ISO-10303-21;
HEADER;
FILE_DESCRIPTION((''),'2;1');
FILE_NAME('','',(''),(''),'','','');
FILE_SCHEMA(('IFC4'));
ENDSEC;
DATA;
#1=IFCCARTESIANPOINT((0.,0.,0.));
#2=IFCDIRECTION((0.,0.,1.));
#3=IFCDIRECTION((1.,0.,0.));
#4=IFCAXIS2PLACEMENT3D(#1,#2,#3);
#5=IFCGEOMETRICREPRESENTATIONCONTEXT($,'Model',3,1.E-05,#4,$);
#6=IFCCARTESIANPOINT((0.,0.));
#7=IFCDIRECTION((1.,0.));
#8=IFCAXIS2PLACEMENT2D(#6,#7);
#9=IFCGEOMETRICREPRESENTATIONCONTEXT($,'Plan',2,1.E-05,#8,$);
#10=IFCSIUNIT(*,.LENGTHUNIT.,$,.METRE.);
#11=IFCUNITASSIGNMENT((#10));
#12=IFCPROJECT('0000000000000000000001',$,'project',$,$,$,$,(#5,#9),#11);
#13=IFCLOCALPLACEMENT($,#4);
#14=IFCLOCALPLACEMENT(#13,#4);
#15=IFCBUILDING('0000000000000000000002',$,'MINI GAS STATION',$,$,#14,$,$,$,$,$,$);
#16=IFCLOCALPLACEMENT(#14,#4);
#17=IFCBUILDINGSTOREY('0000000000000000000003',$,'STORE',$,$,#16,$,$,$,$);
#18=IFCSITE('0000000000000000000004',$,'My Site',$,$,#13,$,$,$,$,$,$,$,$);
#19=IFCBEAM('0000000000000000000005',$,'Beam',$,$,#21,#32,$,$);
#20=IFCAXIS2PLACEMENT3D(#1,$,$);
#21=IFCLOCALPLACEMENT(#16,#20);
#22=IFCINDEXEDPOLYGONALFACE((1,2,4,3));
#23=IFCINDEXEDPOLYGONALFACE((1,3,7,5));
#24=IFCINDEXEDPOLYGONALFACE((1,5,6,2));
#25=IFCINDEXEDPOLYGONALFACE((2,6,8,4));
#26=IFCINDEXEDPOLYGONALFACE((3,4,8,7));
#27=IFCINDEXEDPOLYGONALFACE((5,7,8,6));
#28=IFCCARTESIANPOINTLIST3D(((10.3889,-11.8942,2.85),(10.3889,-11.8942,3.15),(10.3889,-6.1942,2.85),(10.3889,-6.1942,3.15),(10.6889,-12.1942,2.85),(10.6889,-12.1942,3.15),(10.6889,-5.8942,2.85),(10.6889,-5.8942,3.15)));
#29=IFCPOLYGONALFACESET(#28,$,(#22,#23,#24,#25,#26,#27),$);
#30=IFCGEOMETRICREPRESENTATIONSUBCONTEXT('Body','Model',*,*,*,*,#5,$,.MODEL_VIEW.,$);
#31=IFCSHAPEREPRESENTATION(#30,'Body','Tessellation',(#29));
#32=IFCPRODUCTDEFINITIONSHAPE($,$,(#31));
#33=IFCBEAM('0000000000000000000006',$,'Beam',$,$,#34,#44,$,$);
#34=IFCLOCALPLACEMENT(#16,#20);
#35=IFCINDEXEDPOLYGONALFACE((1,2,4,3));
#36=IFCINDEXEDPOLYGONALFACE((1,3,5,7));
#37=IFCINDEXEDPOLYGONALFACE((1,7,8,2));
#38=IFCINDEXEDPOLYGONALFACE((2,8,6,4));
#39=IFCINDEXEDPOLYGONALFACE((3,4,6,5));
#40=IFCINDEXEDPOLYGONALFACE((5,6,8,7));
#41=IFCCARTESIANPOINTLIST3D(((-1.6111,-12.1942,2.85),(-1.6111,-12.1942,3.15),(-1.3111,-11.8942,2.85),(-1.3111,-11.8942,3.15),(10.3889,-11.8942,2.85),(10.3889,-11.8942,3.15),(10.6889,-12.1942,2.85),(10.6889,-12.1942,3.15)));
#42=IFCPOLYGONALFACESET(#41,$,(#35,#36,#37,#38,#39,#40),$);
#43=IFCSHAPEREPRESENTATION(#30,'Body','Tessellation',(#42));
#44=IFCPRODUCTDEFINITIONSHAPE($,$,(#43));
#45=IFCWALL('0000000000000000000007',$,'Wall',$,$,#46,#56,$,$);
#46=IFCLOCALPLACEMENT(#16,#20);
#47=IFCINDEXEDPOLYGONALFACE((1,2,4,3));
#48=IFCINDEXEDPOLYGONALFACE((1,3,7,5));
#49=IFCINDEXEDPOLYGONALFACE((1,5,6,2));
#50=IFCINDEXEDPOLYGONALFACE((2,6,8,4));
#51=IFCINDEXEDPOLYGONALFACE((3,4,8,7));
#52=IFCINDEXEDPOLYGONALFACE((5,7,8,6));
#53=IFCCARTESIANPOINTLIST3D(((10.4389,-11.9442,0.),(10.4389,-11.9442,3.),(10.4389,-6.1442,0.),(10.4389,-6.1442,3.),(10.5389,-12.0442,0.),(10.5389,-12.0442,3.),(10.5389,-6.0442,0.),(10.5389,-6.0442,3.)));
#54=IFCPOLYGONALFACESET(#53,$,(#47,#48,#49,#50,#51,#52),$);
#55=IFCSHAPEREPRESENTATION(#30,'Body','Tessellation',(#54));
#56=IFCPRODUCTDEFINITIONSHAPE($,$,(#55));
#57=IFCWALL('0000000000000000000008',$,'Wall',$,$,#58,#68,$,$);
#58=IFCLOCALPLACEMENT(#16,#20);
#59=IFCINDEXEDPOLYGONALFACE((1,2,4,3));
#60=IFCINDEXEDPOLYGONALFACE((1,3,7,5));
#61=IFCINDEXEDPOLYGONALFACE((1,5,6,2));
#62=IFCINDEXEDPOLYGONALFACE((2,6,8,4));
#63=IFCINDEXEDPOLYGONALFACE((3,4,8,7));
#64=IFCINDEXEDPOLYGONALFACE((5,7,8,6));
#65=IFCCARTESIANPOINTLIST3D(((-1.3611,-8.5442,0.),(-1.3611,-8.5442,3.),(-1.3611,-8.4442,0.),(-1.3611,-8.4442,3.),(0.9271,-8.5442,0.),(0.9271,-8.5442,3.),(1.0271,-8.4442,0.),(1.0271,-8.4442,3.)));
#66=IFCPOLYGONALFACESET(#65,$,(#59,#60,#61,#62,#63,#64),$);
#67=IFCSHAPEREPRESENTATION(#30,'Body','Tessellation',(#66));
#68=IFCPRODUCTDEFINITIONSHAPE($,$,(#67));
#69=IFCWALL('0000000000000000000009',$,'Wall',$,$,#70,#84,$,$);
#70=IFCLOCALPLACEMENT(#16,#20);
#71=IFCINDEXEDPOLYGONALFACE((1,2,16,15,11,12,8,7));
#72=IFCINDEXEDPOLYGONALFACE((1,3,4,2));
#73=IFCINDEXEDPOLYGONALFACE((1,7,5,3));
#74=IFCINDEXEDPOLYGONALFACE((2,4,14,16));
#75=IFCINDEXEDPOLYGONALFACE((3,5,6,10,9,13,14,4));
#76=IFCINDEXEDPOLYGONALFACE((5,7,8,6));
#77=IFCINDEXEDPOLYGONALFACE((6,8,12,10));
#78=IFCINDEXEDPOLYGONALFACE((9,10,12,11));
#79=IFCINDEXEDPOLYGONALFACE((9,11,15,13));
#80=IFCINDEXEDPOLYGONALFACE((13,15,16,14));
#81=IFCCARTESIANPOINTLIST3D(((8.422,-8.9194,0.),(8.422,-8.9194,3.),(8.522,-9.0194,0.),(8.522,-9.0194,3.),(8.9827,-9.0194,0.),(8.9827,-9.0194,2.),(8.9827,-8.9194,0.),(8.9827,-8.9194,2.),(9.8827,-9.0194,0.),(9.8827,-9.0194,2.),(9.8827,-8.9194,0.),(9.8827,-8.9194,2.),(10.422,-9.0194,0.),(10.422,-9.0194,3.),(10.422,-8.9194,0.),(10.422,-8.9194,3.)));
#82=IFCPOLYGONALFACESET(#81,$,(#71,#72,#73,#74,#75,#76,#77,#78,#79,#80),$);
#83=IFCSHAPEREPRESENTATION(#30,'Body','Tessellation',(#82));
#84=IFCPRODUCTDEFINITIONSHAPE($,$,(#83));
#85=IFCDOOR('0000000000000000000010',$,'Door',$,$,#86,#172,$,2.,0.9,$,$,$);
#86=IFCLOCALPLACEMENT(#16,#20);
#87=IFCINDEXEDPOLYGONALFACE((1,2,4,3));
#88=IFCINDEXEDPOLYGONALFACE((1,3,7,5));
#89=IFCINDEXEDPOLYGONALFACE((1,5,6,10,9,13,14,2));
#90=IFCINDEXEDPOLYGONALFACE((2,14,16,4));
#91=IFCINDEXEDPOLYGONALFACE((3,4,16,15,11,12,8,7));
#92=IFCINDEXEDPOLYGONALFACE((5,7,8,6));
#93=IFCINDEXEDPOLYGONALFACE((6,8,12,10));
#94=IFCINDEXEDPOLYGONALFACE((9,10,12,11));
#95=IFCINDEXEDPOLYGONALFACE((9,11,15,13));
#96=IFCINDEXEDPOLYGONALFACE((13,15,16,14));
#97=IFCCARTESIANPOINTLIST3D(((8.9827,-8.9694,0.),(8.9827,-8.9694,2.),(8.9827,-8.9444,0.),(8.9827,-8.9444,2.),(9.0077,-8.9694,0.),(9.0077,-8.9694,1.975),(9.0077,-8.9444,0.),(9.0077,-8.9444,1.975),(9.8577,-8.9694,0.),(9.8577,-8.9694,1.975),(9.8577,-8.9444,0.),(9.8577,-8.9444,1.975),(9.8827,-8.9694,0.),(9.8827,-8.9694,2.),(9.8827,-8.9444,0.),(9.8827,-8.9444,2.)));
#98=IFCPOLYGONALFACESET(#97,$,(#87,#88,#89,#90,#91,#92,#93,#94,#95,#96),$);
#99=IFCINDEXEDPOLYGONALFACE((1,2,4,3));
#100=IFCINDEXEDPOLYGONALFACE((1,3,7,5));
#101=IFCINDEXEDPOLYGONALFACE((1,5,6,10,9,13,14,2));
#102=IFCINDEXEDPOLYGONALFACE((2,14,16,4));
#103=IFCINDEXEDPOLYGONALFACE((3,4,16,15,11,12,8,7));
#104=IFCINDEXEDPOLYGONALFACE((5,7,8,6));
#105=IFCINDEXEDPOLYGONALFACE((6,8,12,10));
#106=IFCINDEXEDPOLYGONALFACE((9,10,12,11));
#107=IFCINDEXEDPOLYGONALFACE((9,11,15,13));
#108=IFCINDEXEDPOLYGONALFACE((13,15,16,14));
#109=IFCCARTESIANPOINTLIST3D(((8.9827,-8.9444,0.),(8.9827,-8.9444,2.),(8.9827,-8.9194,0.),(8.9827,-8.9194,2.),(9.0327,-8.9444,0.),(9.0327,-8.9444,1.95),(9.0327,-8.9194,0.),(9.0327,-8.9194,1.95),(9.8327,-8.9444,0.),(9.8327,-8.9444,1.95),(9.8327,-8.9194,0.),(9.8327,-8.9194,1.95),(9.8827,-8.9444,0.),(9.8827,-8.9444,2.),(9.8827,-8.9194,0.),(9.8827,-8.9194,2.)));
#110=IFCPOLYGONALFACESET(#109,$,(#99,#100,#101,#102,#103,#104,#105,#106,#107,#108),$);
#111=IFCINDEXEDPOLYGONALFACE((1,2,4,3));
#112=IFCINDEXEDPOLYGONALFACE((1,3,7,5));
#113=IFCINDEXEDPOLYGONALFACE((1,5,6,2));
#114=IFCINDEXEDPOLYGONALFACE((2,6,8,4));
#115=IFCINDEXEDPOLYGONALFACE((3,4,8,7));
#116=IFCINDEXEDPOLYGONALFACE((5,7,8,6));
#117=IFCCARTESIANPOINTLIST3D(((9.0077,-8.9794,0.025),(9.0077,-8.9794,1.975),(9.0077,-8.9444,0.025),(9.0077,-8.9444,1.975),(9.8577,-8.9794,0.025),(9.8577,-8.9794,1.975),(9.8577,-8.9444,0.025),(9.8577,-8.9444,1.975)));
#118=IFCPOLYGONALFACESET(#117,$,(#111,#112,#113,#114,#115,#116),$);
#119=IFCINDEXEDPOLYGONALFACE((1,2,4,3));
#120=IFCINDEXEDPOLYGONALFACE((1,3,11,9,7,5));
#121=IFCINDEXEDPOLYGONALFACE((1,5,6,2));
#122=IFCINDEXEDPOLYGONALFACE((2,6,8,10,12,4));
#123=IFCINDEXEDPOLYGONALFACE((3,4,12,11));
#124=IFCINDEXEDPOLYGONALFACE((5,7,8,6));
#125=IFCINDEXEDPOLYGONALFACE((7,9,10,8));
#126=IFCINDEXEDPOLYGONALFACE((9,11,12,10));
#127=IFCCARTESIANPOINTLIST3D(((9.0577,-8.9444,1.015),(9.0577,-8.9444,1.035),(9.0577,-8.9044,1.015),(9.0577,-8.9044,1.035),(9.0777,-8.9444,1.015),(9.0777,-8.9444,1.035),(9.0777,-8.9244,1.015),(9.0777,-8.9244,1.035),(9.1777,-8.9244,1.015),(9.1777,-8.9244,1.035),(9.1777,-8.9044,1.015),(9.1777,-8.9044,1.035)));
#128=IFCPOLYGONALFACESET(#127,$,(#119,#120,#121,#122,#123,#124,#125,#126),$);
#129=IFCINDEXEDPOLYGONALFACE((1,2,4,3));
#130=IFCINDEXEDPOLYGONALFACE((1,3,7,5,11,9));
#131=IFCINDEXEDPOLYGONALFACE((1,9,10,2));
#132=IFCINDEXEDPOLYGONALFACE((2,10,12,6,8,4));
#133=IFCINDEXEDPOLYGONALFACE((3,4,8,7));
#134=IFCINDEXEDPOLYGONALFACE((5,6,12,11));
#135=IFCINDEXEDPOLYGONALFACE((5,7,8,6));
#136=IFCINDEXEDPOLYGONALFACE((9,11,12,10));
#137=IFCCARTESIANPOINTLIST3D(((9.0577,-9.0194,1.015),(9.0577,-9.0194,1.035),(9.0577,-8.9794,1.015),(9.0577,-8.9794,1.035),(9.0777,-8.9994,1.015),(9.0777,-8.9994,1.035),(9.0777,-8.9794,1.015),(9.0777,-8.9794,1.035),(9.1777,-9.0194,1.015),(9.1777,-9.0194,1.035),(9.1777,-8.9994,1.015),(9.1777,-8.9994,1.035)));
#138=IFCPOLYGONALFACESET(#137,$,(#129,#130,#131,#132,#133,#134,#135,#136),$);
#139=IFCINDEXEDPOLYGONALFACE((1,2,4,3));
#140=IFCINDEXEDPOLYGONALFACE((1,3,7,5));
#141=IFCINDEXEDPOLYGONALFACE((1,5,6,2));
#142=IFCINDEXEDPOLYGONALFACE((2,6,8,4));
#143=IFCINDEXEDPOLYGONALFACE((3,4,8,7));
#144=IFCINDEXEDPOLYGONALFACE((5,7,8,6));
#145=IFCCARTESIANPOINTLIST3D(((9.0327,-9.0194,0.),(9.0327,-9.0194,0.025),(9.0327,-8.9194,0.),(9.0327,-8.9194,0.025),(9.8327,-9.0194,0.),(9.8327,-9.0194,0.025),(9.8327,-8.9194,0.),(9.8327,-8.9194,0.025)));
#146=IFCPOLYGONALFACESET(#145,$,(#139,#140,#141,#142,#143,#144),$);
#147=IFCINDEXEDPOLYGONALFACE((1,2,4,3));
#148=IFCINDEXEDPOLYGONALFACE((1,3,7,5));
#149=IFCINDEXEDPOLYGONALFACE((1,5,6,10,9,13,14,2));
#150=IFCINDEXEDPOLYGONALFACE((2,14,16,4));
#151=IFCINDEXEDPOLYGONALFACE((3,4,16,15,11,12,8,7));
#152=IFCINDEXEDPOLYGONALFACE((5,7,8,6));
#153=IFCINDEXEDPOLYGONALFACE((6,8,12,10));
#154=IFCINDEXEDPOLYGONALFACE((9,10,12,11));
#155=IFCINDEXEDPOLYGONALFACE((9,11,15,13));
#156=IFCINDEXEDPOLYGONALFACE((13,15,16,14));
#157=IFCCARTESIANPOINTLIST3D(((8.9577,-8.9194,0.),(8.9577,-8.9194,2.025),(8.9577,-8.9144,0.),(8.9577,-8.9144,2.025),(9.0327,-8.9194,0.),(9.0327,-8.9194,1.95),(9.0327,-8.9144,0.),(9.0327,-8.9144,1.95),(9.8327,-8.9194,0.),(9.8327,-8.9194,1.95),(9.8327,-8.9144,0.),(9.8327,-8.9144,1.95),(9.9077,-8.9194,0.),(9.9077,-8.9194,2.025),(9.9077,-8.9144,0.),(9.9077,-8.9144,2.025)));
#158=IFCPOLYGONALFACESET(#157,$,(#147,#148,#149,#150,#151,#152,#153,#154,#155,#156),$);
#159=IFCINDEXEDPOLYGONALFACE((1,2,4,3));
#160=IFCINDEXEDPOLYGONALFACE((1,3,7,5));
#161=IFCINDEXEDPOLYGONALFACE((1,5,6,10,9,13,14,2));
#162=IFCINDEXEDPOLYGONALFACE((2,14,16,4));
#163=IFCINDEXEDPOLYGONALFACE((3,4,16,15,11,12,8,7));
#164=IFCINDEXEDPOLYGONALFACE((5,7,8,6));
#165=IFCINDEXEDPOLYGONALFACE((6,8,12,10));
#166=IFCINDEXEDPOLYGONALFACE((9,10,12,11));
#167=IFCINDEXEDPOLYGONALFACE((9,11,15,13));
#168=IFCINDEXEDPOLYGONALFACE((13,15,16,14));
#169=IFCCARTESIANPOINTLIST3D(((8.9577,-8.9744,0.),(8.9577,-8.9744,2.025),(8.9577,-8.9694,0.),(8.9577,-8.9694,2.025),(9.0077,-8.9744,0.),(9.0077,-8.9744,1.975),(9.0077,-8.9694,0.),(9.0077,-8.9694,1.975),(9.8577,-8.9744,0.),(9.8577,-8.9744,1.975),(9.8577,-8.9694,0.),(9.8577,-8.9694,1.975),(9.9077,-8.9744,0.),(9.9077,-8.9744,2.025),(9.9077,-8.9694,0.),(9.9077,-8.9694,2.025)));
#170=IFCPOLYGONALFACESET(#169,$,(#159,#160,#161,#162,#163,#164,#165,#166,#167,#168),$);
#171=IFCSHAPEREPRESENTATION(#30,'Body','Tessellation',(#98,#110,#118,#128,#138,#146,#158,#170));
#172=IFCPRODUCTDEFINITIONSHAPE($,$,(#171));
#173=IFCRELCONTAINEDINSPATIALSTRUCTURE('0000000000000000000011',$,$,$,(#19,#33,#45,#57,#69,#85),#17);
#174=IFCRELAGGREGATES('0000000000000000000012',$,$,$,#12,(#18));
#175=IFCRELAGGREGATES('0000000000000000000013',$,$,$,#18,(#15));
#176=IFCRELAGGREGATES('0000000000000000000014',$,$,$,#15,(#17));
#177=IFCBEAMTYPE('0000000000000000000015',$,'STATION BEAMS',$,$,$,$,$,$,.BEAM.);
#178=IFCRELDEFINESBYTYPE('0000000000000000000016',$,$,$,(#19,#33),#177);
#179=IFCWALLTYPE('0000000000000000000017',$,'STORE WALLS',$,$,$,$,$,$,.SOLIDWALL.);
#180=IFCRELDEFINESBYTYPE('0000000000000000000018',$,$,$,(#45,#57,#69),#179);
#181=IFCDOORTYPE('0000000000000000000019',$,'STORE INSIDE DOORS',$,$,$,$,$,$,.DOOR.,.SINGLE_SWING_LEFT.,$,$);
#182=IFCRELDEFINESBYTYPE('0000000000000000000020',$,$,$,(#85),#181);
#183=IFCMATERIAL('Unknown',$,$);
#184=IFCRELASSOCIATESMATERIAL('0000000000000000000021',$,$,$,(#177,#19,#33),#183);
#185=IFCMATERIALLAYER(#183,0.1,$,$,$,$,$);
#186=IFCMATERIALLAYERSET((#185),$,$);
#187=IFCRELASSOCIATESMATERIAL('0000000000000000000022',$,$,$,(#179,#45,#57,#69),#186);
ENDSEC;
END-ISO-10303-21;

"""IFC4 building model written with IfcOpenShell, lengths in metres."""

from ifc_helpers import new_model, entity, si_unit, frame, origin_with_axes, origin_2d_with_axis, place, context, subcontext, project, spatial, line, indexed_curve, rectangle, outline, extrude, clip, halfspace, shape, source, transform, mapped, material, layer, layer_set, layer_usage, material_profile, profile_set, profile_usage, type_object, type_shapes, element, fill, save


model = new_model("IFC4")

# Units and contexts
model_context = context("Model", 3, precision=1e-05, world=origin_with_axes())
plan_context = context("Plan", 2, precision=1e-05, world=origin_2d_with_axis())
body_context_1 = subcontext(model_context, "Body", "Model", "MODEL_VIEW")
body_context_2 = subcontext(plan_context, "Body", "Plan", "PLAN_VIEW")
ifc_project = project(units=[si_unit("LENGTHUNIT", "METRE")], contexts=[model_context, plan_context])

# Site, building, storey
site_placement = place(None, origin_with_axes())
site = spatial("IfcSite", under=ifc_project, at=site_placement, Name="My Site")
building_placement = place(site_placement, origin_with_axes())
building = spatial("IfcBuilding", under=site, at=building_placement, Name="MINI GAS STATION")
storey_placement = place(building_placement, origin_with_axes())
storey = spatial("IfcBuildingStorey", under=building, at=storey_placement, Name="STORE")

# Beams
ifc_material = material(Name="Unknown")
ifc_material_profile = material_profile(ifc_material, rectangle(XDim=0.3, YDim=0.3))
ifc_profile_set = profile_set([ifc_material_profile])
ifc_profile_usage_1 = profile_usage(ifc_profile_set, cardinal=5)
beam_type = type_object("IfcBeamType", Name="STATION BEAMS", PredefinedType="BEAM", material=ifc_profile_set)
beam_1_placement = place(storey_placement, frame((10.5389, -5.8942, 3.0), z_axis=(0.0, -1.0, 0.0), x_axis=(1.0, 0.0, 0.0)))
element("IfcBeam", 1, at=beam_1_placement, inside=storey, type_object=beam_type, material=ifc_profile_usage_1, Name="Beam", context=body_context_1, shape_type="Clipping", body=[
    clip(clip(extrude(rectangle(XDim=0.3, YDim=0.3), origin_with_axes(), (0.0, 0.0, 1.0), 6.3), halfspace(frame((0.15, -3.0, 6.3), z_axis=(-0.707105, 0.0, 0.707108), x_axis=(0.0, 1.0, 0.0)), False)), halfspace(frame((0.15, -3.0, 0.0), z_axis=(-0.707108, 0.0, -0.707105), x_axis=(0.0, 1.0, 0.0)), False)),
])
ifc_profile_usage_2 = profile_usage(ifc_profile_set, cardinal=5)
beam_2_placement = place(storey_placement, frame((10.6889, -12.0442, 3.0), z_axis=(-1.0, -0.000001, 0.000001), x_axis=(0.000001, -1.0, 0.0)))
element("IfcBeam", 2, at=beam_2_placement, inside=storey, type_object=beam_type, material=ifc_profile_usage_2, Name="Beam", context=body_context_1, shape_type="Clipping", body=[
    clip(clip(extrude(rectangle(XDim=0.3, YDim=0.3), origin_with_axes(), (0.0, 0.0, 1.0), 12.3), halfspace(frame((0.15, -3.0, 12.3), z_axis=(-0.707111, 0.0, 0.707103), x_axis=(-0.000001, 1.0, 0.0)), False)), halfspace(frame((0.15, -3.0, 0.0), z_axis=(-0.707108, 0.0, -0.707106), x_axis=(0.000001, 1.0, 0.0)), False)),
])

# Wall
ifc_layer_1 = layer(ifc_material, 0.1)
ifc_layer_set_1 = layer_set([ifc_layer_1])
ifc_layer_usage_1 = layer_usage(ifc_layer_set_1, "AXIS2", "POSITIVE", 0.0)
wall_type_1 = type_object("IfcWallType", Name="STORE WALLS", PredefinedType="SOLIDWALL", material=ifc_layer_set_1)
wall_1_placement = place(storey_placement, frame((10.5389, -12.0442, 0.0), z_axis=(0.0, 0.0, 1.0), x_axis=(0.0, 1.0, 0.0)))
element("IfcWall", 3, at=wall_1_placement, inside=storey, type_object=wall_type_1, material=ifc_layer_usage_1, Name="Wall", context=body_context_1, shape_type="SweptSolid", body=[
    extrude(outline(indexed_curve([(0.0, 0.0), (0.1, 0.1), (5.9, 0.1), (6.0, 0.0)], segments=[line(1, 2, 3, 4, 1)])), origin_with_axes(), (0.0, 0.0, 1.0), 3.0),
])

# Wall
ifc_layer_usage_2 = layer_usage(ifc_layer_set_1, "AXIS2", "POSITIVE", 0.0)
wall_2_placement = place(storey_placement, frame((1.0271, -8.4442, 0.0), z_axis=(0.0, 0.0, 1.0), x_axis=(-1.0, 0.0, 0.0)))
element("IfcWall", 4, at=wall_2_placement, inside=storey, type_object=wall_type_1, material=ifc_layer_usage_2, Name="Wall", context=body_context_1, shape_type="SweptSolid", body=[
    extrude(outline(indexed_curve([(0.0, 0.0), (0.1, 0.1), (2.3881, 0.1), (2.3881, 0.0)], segments=[line(1, 2, 3, 4, 1)])), origin_with_axes(), (0.0, 0.0, 1.0), 3.0),
])

# Wall, opening, door
ifc_layer_usage_3 = layer_usage(ifc_layer_set_1, "AXIS2", "POSITIVE", 0.0)
wall_3_placement = place(storey_placement, frame((10.422, -8.9194, 0.0), z_axis=(0.0, 0.0, 1.0), x_axis=(-1.0, 0.0, 0.0)))
wall_3 = element("IfcWall", 5, at=wall_3_placement, inside=storey, type_object=wall_type_1, material=ifc_layer_usage_3, Name="Wall", context=body_context_1, shape_type="SweptSolid", body=[
    extrude(outline(indexed_curve([(0.0, 0.0), (0.0, 0.1), (1.9, 0.1), (2.0, 0.0)], segments=[line(1, 2, 3, 4, 1)])), origin_with_axes(), (0.0, 0.0, 1.0), 3.0),
])
shared_shape_1 = source(origin_with_axes(), body_context_1, "Body", "SweptSolid", [
    extrude(outline(indexed_curve([(0.0, 0.0), (0.9, 0.0), (0.9, 2.0), (0.0, 2.0)], segments=[line(1, 2, 3, 4, 1)])), frame((0.0, -0.6, 0.0), z_axis=(0.0, -1.0, 0.0), x_axis=(1.0, 0.0, 0.0)), (0.0, 0.0, -1.0), 1.2),
])
opening_1_placement = place(wall_3_placement, frame((0.5393, 0.0, 0.0), z_axis=(0.0, 0.0, 1.0), x_axis=(1.0, 0.0, 0.0)))
opening_1 = element("IfcOpeningElement", 6, at=opening_1_placement, cuts=wall_3, PredefinedType="OPENING", context=body_context_1, shape_type="MappedRepresentation", body=[
    mapped(shared_shape_1, transform((0.0, 0.0, 0.0), x_axis=(1.0, 0.0, 0.0), y_axis=(0.0, 1.0, 0.0), z_axis=(0.0, 0.0, 1.0), scale=1.0)),
])
door_type_1 = type_object("IfcDoorType", Name="STORE INSIDE DOORS", OperationType="SINGLE_SWING_LEFT", PredefinedType="DOOR")
shared_shape_2 = source(origin_with_axes(), body_context_1, "Body", "SweptSolid", [
    extrude(outline(indexed_curve([(0.0, 0.0), (0.0, 2.0), (0.9, 2.0), (0.9, 0.0), (0.875, 0.0), (0.875, 1.975), (0.025, 1.975), (0.025, 0.0)], segments=[line(1, 2, 3, 4, 5, 6, 7, 8, 1)])), frame((0.0, 0.025, 0.0), z_axis=(0.0, -1.0, 0.0), x_axis=(1.0, 0.0, 0.0)), (0.0, 0.0, -1.0), 0.025),
    extrude(outline(indexed_curve([(0.0, 0.0), (0.0, 2.0), (0.9, 2.0), (0.9, 0.0), (0.85, 0.0), (0.85, 1.95), (0.05, 1.95), (0.05, 0.0)], segments=[line(1, 2, 3, 4, 5, 6, 7, 8, 1)])), frame((0.0, 0.0, 0.0), z_axis=(0.0, -1.0, 0.0), x_axis=(1.0, 0.0, 0.0)), (0.0, 0.0, -1.0), 0.025),
    extrude(outline(indexed_curve([(0.0, 0.0), (0.85, 0.0), (0.85, 0.035), (0.0, 0.035)], segments=[line(1, 2, 3, 4, 1)])), frame((0.025, 0.025, 0.025), z_axis=(0.0, 0.0, 1.0), x_axis=(1.0, 0.0, 0.0)), (0.0, 0.0, 1.0), 1.95),
    extrude(outline(indexed_curve([(0.0, 0.0), (0.0, -0.04), (-0.12, -0.04), (-0.12, -0.02), (-0.02, -0.02), (-0.02, 0.0)], segments=[line(1, 2, 3, 4, 5, 6, 1)])), frame((0.825, 0.025, 1.015), z_axis=(0.0, 0.0, 1.0), x_axis=(1.0, 0.0, 0.0)), (0.0, 0.0, 1.0), 0.02),
    extrude(outline(indexed_curve([(0.0, 0.0), (0.0, 0.04), (-0.12, 0.04), (-0.12, 0.02), (-0.02, 0.02), (-0.02, 0.0)], segments=[line(1, 2, 3, 4, 5, 6, 1)])), frame((0.825, 0.06, 1.015), z_axis=(0.0, 0.0, 1.0), x_axis=(1.0, 0.0, 0.0)), (0.0, 0.0, 1.0), 0.02),
    extrude(outline(indexed_curve([(0.0, 0.0), (0.8, 0.0), (0.8, 0.1), (0.0, 0.1)], segments=[line(1, 2, 3, 4, 1)])), frame((0.05, 0.0, 0.0), z_axis=(0.0, 0.0, 1.0), x_axis=(1.0, 0.0, 0.0)), (0.0, 0.0, 1.0), 0.025),
    extrude(outline(indexed_curve([(0.0, 0.0), (0.0, 2.025), (0.95, 2.025), (0.95, 0.0), (0.875, 0.0), (0.875, 1.95), (0.075, 1.95), (0.075, 0.0)], segments=[line(1, 2, 3, 4, 5, 6, 7, 8, 1)])), frame((-0.025, -0.005, 0.0), z_axis=(0.0, -1.0, 0.0), x_axis=(1.0, 0.0, 0.0)), (0.0, 0.0, -1.0), 0.005),
    extrude(outline(indexed_curve([(0.0, 0.0), (0.0, 2.025), (0.95, 2.025), (0.95, 0.0), (0.9, 0.0), (0.9, 1.975), (0.05, 1.975), (0.05, 0.0)], segments=[line(1, 2, 3, 4, 5, 6, 7, 8, 1)])), frame((-0.025, 0.05, 0.0), z_axis=(0.0, -1.0, 0.0), x_axis=(1.0, 0.0, 0.0)), (0.0, 0.0, -1.0), 0.005),
])
shared_shape_3 = source(origin_with_axes(), body_context_2, "Body", "Curve2D", [
    entity("IfcIndexedPolyCurve", entity("IfcCartesianPointList2D", [[0.0, 0.0], [0.0, 0.05], [0.025, 0.05], [0.025, 0.025], [0.05, 0.025], [0.05, 0.0]]), [entity("IfcLineIndex", [1, 2, 3, 4, 5, 6, 1])]),
    entity("IfcIndexedPolyCurve", entity("IfcCartesianPointList2D", [[0.9, 0.0], [0.9, 0.05], [0.875, 0.05], [0.875, 0.025], [0.85, 0.025], [0.85, 0.0]]), [entity("IfcLineIndex", [1, 2, 3, 4, 5, 6, 1])]),
    entity("IfcTrimmedCurve", entity("IfcEllipse", entity("IfcAxis2Placement2D", entity("IfcCartesianPoint", [0.06, 0.05]), entity("IfcDirection", [1.0, 0.0])), 0.815, 0.85), [entity("IfcCartesianPoint", [0.875, 0.05])], [entity("IfcCartesianPoint", [0.06, 0.9])], True, "CARTESIAN"),
    entity("IfcIndexedPolyCurve", entity("IfcCartesianPointList2D", [[0.025, 0.05], [0.06, 0.05], [0.06, 0.9], [0.025, 0.9]]), [entity("IfcLineIndex", [1, 2, 3, 4, 1])]),
])
type_shapes(door_type_1, [shared_shape_2, shared_shape_3])
door_1_placement = place(opening_1_placement, frame((0.0, 0.0, 0.0), z_axis=(0.0, 0.0, 1.0), x_axis=(1.0, 0.0, 0.0)))
door_1 = element("IfcDoor", 7, at=door_1_placement, inside=storey, type_object=door_type_1, Name="Door", OverallHeight=2.0, OverallWidth=0.9, shapes=[
    shape(body_context_1, "Body", "MappedRepresentation", [mapped(shared_shape_2, transform((0.0, 0.0, 0.0), x_axis=(1.0, 0.0, 0.0), y_axis=(0.0, 1.0, 0.0), z_axis=(0.0, 0.0, 1.0), scale=1.0))]),
    shape(body_context_2, "Body", "MappedRepresentation", [mapped(shared_shape_3, transform((0.0, 0.0, 0.0), x_axis=(1.0, 0.0, 0.0), y_axis=(0.0, 1.0, 0.0), z_axis=(0.0, 0.0, 1.0), scale=1.0))]),
])
fill(opening_1, door_1)

save(model, "model.ifc")
